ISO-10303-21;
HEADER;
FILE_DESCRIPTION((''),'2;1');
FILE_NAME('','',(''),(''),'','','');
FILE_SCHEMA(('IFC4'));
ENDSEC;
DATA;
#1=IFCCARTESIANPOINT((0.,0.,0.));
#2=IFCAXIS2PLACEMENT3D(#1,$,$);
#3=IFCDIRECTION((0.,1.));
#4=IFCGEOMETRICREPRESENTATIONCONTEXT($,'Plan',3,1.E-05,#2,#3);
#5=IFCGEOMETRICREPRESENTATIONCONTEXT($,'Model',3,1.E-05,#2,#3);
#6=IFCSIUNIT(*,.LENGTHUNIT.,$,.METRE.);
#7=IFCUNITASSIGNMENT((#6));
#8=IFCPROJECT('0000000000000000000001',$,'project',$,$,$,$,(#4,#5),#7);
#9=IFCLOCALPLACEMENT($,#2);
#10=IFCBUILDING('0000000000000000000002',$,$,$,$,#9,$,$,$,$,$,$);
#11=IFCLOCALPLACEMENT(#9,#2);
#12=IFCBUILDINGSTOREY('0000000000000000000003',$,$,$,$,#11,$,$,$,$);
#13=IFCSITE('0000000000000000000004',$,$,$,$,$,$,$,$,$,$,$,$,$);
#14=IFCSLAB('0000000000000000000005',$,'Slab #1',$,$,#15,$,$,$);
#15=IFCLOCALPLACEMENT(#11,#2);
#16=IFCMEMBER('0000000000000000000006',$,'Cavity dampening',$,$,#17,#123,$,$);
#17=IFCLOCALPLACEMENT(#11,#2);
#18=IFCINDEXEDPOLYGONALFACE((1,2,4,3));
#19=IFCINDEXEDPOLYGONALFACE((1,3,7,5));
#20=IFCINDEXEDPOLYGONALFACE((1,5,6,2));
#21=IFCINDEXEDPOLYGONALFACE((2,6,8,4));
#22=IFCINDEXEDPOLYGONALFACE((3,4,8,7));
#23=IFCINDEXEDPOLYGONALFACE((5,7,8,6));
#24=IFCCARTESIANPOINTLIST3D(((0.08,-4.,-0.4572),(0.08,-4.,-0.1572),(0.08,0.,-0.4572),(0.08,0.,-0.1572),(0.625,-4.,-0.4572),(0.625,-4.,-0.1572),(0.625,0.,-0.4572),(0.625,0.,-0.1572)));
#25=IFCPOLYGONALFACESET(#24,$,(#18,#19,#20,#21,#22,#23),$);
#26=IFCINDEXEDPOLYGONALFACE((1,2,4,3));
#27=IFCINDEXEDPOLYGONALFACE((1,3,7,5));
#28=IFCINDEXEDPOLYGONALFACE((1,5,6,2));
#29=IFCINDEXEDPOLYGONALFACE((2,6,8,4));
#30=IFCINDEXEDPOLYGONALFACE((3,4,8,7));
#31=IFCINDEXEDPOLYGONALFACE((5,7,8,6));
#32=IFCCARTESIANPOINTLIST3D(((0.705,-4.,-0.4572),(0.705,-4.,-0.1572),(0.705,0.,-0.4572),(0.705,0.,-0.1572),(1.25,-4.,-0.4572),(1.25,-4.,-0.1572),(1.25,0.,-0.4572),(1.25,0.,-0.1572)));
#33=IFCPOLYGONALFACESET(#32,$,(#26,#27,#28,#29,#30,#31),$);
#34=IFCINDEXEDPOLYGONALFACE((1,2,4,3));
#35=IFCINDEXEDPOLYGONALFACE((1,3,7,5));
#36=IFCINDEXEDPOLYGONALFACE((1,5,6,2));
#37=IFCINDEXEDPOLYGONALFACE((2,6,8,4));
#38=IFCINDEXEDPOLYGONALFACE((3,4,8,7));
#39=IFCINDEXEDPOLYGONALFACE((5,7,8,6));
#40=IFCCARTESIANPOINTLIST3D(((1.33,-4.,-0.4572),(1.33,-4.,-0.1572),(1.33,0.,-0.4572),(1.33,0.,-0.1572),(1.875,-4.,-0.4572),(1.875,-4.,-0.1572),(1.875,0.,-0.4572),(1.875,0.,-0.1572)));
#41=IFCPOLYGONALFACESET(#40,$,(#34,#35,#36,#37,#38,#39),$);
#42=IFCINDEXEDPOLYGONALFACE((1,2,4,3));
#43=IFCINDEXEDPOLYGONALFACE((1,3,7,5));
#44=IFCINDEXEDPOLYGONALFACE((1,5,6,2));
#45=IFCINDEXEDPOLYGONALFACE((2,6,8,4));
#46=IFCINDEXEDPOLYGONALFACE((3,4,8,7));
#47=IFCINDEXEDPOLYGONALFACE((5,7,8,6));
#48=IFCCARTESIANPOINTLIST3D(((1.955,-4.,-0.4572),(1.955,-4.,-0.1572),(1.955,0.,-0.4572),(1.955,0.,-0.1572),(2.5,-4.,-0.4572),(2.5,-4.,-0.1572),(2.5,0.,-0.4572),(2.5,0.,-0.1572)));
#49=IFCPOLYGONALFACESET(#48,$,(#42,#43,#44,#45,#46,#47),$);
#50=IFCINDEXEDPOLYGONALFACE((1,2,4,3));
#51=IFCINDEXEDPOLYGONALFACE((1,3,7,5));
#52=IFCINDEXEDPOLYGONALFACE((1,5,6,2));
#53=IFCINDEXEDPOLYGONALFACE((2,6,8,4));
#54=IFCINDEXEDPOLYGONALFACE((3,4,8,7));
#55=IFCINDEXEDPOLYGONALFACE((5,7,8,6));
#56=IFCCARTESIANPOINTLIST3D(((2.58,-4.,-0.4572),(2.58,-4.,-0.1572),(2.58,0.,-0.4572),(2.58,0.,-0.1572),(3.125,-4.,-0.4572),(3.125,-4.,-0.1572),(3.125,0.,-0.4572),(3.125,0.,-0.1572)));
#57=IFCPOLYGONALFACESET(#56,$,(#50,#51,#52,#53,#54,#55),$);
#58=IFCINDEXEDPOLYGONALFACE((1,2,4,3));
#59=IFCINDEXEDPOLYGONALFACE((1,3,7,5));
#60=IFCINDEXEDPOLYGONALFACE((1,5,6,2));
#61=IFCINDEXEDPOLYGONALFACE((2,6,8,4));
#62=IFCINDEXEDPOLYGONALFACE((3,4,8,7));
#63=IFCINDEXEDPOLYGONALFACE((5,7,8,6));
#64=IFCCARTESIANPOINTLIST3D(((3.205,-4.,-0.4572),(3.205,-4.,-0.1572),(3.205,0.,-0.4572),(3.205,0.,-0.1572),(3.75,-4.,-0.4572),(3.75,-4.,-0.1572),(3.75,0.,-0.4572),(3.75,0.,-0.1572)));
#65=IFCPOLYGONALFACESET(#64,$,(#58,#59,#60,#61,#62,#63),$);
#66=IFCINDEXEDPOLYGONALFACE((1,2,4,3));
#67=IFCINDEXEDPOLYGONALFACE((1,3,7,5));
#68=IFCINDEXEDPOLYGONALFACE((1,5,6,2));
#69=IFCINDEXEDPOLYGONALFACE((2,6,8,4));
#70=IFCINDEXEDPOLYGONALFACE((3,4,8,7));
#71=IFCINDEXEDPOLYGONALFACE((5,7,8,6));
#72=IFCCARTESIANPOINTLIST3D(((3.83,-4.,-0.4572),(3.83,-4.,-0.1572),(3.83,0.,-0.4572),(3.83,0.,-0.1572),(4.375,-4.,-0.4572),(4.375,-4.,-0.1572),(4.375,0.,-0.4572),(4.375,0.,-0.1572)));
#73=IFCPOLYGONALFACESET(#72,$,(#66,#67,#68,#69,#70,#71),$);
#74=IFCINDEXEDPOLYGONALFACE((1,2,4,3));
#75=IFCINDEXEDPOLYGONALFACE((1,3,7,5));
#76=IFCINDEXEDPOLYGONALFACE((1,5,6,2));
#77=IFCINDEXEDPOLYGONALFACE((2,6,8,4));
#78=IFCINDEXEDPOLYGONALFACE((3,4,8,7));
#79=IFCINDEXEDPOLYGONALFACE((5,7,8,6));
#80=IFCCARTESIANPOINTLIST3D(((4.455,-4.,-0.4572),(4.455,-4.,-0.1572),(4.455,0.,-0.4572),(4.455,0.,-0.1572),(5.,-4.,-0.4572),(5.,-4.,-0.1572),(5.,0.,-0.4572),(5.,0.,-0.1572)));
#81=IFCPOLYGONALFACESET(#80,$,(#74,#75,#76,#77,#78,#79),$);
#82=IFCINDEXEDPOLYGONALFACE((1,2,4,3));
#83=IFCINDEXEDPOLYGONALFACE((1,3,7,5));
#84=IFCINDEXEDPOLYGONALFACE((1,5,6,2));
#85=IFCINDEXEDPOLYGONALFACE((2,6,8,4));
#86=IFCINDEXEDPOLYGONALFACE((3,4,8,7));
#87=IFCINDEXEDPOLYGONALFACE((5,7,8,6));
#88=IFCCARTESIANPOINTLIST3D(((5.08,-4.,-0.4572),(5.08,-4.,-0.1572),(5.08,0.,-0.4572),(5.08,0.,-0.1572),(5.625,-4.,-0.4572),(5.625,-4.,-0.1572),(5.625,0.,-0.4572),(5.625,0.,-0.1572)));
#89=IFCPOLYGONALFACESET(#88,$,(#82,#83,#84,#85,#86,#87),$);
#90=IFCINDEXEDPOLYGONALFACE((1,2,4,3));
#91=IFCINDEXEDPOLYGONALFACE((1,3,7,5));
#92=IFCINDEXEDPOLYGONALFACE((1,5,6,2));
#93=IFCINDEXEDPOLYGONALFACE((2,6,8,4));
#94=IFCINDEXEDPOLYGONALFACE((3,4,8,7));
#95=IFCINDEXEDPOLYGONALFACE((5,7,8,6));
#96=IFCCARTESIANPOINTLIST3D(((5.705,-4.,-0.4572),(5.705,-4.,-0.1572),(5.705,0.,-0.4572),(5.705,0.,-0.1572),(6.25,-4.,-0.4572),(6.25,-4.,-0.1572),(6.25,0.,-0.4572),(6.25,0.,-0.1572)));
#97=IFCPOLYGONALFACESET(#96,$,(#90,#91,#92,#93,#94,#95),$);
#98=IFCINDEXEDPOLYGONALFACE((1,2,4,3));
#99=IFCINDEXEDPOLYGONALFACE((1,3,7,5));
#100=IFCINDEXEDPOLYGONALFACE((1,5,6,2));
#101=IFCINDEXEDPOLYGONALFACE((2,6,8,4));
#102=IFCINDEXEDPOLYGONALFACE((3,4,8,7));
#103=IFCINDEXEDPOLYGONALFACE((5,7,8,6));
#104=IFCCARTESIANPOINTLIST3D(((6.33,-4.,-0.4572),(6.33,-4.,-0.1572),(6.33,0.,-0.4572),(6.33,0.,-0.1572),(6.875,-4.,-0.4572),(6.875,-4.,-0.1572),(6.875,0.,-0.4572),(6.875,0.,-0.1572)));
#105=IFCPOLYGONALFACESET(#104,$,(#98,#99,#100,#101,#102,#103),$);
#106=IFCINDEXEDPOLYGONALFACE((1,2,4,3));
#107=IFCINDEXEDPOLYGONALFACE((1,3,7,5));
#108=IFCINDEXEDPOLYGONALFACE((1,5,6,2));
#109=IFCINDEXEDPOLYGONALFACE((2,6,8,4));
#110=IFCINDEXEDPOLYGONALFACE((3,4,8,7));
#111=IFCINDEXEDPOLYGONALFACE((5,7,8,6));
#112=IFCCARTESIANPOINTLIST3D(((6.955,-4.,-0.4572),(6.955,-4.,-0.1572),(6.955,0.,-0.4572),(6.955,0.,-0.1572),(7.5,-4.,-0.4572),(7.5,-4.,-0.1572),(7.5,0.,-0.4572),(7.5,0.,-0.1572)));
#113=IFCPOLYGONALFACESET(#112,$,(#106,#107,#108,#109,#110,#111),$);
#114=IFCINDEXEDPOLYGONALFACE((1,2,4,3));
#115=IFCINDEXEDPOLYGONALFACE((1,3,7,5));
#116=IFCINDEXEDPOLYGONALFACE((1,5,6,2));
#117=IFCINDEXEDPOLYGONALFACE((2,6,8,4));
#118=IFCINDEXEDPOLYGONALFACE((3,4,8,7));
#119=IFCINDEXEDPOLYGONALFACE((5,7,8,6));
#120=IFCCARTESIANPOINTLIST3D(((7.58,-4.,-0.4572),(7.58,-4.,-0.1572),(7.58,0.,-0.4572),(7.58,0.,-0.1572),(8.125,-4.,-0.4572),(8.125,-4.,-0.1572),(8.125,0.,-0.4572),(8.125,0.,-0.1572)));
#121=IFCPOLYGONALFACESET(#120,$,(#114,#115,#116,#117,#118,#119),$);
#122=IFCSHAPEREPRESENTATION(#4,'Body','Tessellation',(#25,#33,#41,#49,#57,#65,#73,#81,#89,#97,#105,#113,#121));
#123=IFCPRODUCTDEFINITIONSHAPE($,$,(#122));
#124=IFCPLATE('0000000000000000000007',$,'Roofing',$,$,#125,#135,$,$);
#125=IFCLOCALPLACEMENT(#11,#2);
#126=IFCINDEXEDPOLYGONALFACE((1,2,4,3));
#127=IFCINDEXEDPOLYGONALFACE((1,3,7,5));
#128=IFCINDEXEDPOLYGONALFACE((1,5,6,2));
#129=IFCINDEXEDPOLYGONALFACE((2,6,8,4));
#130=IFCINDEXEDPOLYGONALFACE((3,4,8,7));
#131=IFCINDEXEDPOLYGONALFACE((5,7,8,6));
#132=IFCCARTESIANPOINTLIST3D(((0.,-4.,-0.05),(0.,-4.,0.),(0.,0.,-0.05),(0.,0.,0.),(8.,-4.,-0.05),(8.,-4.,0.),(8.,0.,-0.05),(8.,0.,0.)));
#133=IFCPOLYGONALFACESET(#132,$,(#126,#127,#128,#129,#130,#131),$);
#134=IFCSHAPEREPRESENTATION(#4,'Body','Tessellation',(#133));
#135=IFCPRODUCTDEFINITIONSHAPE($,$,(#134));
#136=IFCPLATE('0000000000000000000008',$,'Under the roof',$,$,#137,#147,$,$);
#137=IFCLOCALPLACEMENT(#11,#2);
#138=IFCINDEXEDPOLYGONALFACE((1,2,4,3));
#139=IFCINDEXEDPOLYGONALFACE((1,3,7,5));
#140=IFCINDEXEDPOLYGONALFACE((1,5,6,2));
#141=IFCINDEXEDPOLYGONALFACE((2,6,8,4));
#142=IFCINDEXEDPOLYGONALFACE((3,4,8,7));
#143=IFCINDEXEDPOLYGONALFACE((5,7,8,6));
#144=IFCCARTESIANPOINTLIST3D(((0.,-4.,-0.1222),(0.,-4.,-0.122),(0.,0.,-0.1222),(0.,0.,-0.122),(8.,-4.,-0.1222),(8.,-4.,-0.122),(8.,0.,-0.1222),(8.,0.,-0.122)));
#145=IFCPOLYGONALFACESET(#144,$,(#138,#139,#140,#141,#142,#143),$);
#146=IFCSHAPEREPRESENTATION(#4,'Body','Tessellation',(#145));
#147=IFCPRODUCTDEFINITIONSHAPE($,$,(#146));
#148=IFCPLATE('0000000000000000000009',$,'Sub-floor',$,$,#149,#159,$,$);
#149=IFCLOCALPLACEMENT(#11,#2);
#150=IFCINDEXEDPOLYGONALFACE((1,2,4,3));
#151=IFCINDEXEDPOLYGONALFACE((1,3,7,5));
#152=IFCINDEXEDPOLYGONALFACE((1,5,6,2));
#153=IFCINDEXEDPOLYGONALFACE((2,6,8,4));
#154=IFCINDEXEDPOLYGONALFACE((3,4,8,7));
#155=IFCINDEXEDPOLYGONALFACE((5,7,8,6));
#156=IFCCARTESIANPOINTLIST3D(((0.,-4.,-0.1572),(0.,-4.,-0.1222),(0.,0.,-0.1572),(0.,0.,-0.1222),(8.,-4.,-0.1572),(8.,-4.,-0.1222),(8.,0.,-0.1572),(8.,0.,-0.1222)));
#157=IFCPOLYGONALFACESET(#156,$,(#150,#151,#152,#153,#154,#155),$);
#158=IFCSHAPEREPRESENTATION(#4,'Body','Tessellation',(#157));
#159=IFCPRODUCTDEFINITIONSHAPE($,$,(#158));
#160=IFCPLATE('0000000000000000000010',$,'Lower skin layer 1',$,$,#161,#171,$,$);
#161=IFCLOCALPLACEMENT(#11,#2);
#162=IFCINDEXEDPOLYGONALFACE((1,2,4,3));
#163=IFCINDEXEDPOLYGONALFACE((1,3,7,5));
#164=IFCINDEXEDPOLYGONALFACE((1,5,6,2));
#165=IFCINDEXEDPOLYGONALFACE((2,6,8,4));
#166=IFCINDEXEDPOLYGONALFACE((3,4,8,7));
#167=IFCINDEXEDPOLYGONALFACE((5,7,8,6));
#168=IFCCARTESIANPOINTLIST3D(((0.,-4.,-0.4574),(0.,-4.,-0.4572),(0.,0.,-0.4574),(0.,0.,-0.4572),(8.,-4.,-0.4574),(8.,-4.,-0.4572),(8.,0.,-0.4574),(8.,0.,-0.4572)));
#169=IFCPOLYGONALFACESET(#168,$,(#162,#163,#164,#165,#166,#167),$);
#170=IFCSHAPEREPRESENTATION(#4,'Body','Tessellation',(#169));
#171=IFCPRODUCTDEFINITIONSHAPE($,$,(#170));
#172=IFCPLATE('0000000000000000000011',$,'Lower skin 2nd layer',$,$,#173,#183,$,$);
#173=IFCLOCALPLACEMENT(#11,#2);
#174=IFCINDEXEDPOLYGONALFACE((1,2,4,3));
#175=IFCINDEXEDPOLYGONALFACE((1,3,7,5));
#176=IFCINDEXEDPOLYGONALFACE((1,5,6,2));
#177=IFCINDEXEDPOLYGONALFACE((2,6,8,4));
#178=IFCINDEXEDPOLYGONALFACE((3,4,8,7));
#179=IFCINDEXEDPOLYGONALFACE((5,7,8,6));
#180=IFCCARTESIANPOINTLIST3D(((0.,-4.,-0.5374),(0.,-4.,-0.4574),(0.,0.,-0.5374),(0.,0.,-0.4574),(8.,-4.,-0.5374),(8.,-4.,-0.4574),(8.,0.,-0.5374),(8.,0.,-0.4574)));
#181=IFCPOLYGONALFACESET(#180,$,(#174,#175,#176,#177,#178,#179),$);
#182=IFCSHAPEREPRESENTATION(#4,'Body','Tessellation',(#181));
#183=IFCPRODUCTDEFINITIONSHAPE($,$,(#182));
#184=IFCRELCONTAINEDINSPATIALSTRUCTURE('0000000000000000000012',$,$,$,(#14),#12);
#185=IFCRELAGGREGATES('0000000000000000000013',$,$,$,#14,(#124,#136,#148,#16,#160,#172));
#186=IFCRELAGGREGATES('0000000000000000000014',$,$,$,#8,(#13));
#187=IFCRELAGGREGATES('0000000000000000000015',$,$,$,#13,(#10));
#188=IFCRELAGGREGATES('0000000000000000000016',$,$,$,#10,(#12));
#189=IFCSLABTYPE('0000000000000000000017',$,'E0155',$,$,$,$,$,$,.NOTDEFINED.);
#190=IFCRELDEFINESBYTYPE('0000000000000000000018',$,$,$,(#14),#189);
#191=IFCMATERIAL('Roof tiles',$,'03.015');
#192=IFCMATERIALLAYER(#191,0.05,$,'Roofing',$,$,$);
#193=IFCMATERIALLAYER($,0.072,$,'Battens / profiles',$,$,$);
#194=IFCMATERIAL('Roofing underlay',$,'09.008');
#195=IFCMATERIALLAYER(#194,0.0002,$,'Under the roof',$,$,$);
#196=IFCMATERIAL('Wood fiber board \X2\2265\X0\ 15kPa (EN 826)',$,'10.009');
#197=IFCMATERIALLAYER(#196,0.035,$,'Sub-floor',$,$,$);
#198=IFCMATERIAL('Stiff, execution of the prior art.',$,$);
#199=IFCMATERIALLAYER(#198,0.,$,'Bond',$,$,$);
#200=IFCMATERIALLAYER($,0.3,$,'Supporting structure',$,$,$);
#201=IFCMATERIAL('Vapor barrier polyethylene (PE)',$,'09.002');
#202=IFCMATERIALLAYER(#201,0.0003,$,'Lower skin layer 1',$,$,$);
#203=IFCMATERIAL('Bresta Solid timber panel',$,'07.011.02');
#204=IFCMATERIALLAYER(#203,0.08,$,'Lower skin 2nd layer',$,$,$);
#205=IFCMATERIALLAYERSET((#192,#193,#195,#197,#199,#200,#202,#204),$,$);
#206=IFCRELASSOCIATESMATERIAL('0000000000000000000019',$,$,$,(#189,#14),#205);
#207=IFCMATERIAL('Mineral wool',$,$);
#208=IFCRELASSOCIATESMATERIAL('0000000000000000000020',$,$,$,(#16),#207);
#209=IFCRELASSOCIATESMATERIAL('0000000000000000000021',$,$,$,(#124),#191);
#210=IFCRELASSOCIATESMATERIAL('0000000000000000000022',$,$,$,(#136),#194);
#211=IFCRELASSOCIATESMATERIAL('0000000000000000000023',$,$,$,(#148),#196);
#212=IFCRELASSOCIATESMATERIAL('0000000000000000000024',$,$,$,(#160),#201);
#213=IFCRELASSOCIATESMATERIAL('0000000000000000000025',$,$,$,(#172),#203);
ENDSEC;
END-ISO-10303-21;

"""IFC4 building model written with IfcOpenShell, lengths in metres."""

from ifc_helpers import new_model, si_unit, direction, frame, frame_2d, origin, origin_with_axes, place, context, project, spatial, rectangle, extrude, material, layer, layer_set, type_object, element, aggregate, save


model = new_model("IFC4")

# Units and contexts
plan_context = context("Plan", 3, precision=1e-05, world=origin(), true_north=direction((0.0, 1.0)))
model_context = context("Model", 3, precision=1e-05, world=origin(), true_north=direction((0.0, 1.0)))
ifc_project = project(units=[si_unit("LENGTHUNIT", "METRE")], contexts=[plan_context, model_context])

# Site, building, storey
site = spatial("IfcSite", under=ifc_project)
building_placement = place(None, origin())
building = spatial("IfcBuilding", under=site, at=building_placement)
storey_placement = place(building_placement, origin())
storey = spatial("IfcBuildingStorey", under=building, at=storey_placement)

# Slab, member, plates
ifc_material_1 = material(Name="Roof tiles", Category="03.015")
ifc_layer_1 = layer(ifc_material_1, 0.05, Name="Roofing")
ifc_layer_2 = layer(None, 0.072, Name="Battens / profiles")
ifc_material_2 = material(Name="Roofing underlay", Category="09.008")
ifc_layer_3 = layer(ifc_material_2, 0.0002, Name="Under the roof")
ifc_material_3 = material(Name="Wood fiber board ≥ 15kPa (EN 826)", Category="10.009")
ifc_layer_4 = layer(ifc_material_3, 0.035, Name="Sub-floor")
ifc_material_4 = material(Name="Stiff, execution of the prior art.")
ifc_layer_5 = layer(ifc_material_4, 0.0, Name="Bond")
ifc_layer_6 = layer(None, 0.3, Name="Supporting structure")
ifc_material_5 = material(Name="Vapor barrier polyethylene (PE)", Category="09.002")
ifc_layer_7 = layer(ifc_material_5, 0.0003, Name="Lower skin layer 1")
ifc_material_6 = material(Name="Bresta Solid timber panel", Category="07.011.02")
ifc_layer_8 = layer(ifc_material_6, 0.08, Name="Lower skin 2nd layer")
ifc_layer_set = layer_set([ifc_layer_1, ifc_layer_2, ifc_layer_3, ifc_layer_4, ifc_layer_5, ifc_layer_6, ifc_layer_7, ifc_layer_8])
slab_type = type_object("IfcSlabType", Name="E0155", PredefinedType="NOTDEFINED", material=ifc_layer_set)
slab_placement = place(None, frame((0.0, 0.0, 0.0), z_axis=(0.0, 0.0, -1.0), x_axis=(1.0, 0.0, 0.0)))
slab = element("IfcSlab", 1, at=slab_placement, inside=storey, type_object=slab_type, material=ifc_layer_set, Name="Slab #1")
ifc_material_7 = material(Name="Mineral wool")
member_1_placement = place(slab_placement, origin())
member_1 = element("IfcMember", 2, at=member_1_placement, material=ifc_material_7, Name="Cavity dampening", context=plan_context, shape_type="SweptSolid", body=[
    extrude(rectangle(XDim=0.545, YDim=0.3, at=frame_2d((0.2725, 0.15), x_axis=(1.0, 0.0))), frame((0.08, 4.0, 0.1572), z_axis=(0.0, -1.0, 0.0), x_axis=(1.0, 0.0, 0.0)), (0.0, 0.0, 1.0), 4.0),
    extrude(rectangle(XDim=0.545, YDim=0.3, at=frame_2d((0.2725, 0.15), x_axis=(1.0, 0.0))), frame((0.705, 4.0, 0.1572), z_axis=(0.0, -1.0, 0.0), x_axis=(1.0, 0.0, 0.0)), (0.0, 0.0, 1.0), 4.0),
    extrude(rectangle(XDim=0.545, YDim=0.3, at=frame_2d((0.2725, 0.15), x_axis=(1.0, 0.0))), frame((1.33, 4.0, 0.1572), z_axis=(0.0, -1.0, 0.0), x_axis=(1.0, 0.0, 0.0)), (0.0, 0.0, 1.0), 4.0),
    extrude(rectangle(XDim=0.545, YDim=0.3, at=frame_2d((0.2725, 0.15), x_axis=(1.0, 0.0))), frame((1.955, 4.0, 0.1572), z_axis=(0.0, -1.0, 0.0), x_axis=(1.0, 0.0, 0.0)), (0.0, 0.0, 1.0), 4.0),
    extrude(rectangle(XDim=0.545, YDim=0.3, at=frame_2d((0.2725, 0.15), x_axis=(1.0, 0.0))), frame((2.58, 4.0, 0.1572), z_axis=(0.0, -1.0, 0.0), x_axis=(1.0, 0.0, 0.0)), (0.0, 0.0, 1.0), 4.0),
    extrude(rectangle(XDim=0.545, YDim=0.3, at=frame_2d((0.2725, 0.15), x_axis=(1.0, 0.0))), frame((3.205, 4.0, 0.1572), z_axis=(0.0, -1.0, 0.0), x_axis=(1.0, 0.0, 0.0)), (0.0, 0.0, 1.0), 4.0),
    extrude(rectangle(XDim=0.545, YDim=0.3, at=frame_2d((0.2725, 0.15), x_axis=(1.0, 0.0))), frame((3.83, 4.0, 0.1572), z_axis=(0.0, -1.0, 0.0), x_axis=(1.0, 0.0, 0.0)), (0.0, 0.0, 1.0), 4.0),
    extrude(rectangle(XDim=0.545, YDim=0.3, at=frame_2d((0.2725, 0.15), x_axis=(1.0, 0.0))), frame((4.455, 4.0, 0.1572), z_axis=(0.0, -1.0, 0.0), x_axis=(1.0, 0.0, 0.0)), (0.0, 0.0, 1.0), 4.0),
    extrude(rectangle(XDim=0.545, YDim=0.3, at=frame_2d((0.2725, 0.15), x_axis=(1.0, 0.0))), frame((5.08, 4.0, 0.1572), z_axis=(0.0, -1.0, 0.0), x_axis=(1.0, 0.0, 0.0)), (0.0, 0.0, 1.0), 4.0),
    extrude(rectangle(XDim=0.545, YDim=0.3, at=frame_2d((0.2725, 0.15), x_axis=(1.0, 0.0))), frame((5.705, 4.0, 0.1572), z_axis=(0.0, -1.0, 0.0), x_axis=(1.0, 0.0, 0.0)), (0.0, 0.0, 1.0), 4.0),
    extrude(rectangle(XDim=0.545, YDim=0.3, at=frame_2d((0.2725, 0.15), x_axis=(1.0, 0.0))), frame((6.33, 4.0, 0.1572), z_axis=(0.0, -1.0, 0.0), x_axis=(1.0, 0.0, 0.0)), (0.0, 0.0, 1.0), 4.0),
    extrude(rectangle(XDim=0.545, YDim=0.3, at=frame_2d((0.2725, 0.15), x_axis=(1.0, 0.0))), frame((6.955, 4.0, 0.1572), z_axis=(0.0, -1.0, 0.0), x_axis=(1.0, 0.0, 0.0)), (0.0, 0.0, 1.0), 4.0),
    extrude(rectangle(XDim=0.545, YDim=0.3, at=frame_2d((0.2725, 0.15), x_axis=(1.0, 0.0))), frame((7.58, 4.0, 0.1572), z_axis=(0.0, -1.0, 0.0), x_axis=(1.0, 0.0, 0.0)), (0.0, 0.0, 1.0), 4.0),
])
plate_1_placement = place(slab_placement, origin())
plate_1 = element("IfcPlate", 3, at=plate_1_placement, material=ifc_material_1, Name="Roofing", context=plan_context, shape_type="SweptSolid", body=[
    extrude(rectangle(XDim=8.0, YDim=4.0, at=frame_2d((4.0, 2.0), x_axis=(1.0, 0.0))), origin_with_axes(), (0.0, 0.0, 1.0), 0.05),
])
plate_2_placement = place(slab_placement, origin())
plate_2 = element("IfcPlate", 4, at=plate_2_placement, material=ifc_material_2, Name="Under the roof", context=plan_context, shape_type="SweptSolid", body=[
    extrude(rectangle(XDim=8.0, YDim=4.0, at=frame_2d((4.0, 2.0), x_axis=(1.0, 0.0))), frame((0.0, 0.0, 0.122), z_axis=(0.0, 0.0, 1.0), x_axis=(1.0, 0.0, 0.0)), (0.0, 0.0, 1.0), 0.0002),
])
plate_3_placement = place(slab_placement, origin())
plate_3 = element("IfcPlate", 5, at=plate_3_placement, material=ifc_material_3, Name="Sub-floor", context=plan_context, shape_type="SweptSolid", body=[
    extrude(rectangle(XDim=8.0, YDim=4.0, at=frame_2d((4.0, 2.0), x_axis=(1.0, 0.0))), frame((0.0, 0.0, 0.1222), z_axis=(0.0, 0.0, 1.0), x_axis=(1.0, 0.0, 0.0)), (0.0, 0.0, 1.0), 0.035),
])
plate_4_placement = place(slab_placement, origin())
plate_4 = element("IfcPlate", 6, at=plate_4_placement, material=ifc_material_5, Name="Lower skin layer 1", context=plan_context, shape_type="SweptSolid", body=[
    extrude(rectangle(XDim=8.0, YDim=4.0, at=frame_2d((4.0, 2.0), x_axis=(1.0, 0.0))), frame((0.0, 0.0, 0.4572), z_axis=(0.0, 0.0, 1.0), x_axis=(1.0, 0.0, 0.0)), (0.0, 0.0, 1.0), 0.0003),
])
plate_5_placement = place(slab_placement, origin())
plate_5 = element("IfcPlate", 7, at=plate_5_placement, material=ifc_material_6, Name="Lower skin 2nd layer", context=plan_context, shape_type="SweptSolid", body=[
    extrude(rectangle(XDim=8.0, YDim=4.0, at=frame_2d((4.0, 2.0), x_axis=(1.0, 0.0))), frame((0.0, 0.0, 0.4574), z_axis=(0.0, 0.0, 1.0), x_axis=(1.0, 0.0, 0.0)), (0.0, 0.0, 1.0), 0.08),
])
aggregate(slab, [plate_1, plate_2, plate_3, member_1, plate_4, plate_5])

save(model, "model.ifc")
